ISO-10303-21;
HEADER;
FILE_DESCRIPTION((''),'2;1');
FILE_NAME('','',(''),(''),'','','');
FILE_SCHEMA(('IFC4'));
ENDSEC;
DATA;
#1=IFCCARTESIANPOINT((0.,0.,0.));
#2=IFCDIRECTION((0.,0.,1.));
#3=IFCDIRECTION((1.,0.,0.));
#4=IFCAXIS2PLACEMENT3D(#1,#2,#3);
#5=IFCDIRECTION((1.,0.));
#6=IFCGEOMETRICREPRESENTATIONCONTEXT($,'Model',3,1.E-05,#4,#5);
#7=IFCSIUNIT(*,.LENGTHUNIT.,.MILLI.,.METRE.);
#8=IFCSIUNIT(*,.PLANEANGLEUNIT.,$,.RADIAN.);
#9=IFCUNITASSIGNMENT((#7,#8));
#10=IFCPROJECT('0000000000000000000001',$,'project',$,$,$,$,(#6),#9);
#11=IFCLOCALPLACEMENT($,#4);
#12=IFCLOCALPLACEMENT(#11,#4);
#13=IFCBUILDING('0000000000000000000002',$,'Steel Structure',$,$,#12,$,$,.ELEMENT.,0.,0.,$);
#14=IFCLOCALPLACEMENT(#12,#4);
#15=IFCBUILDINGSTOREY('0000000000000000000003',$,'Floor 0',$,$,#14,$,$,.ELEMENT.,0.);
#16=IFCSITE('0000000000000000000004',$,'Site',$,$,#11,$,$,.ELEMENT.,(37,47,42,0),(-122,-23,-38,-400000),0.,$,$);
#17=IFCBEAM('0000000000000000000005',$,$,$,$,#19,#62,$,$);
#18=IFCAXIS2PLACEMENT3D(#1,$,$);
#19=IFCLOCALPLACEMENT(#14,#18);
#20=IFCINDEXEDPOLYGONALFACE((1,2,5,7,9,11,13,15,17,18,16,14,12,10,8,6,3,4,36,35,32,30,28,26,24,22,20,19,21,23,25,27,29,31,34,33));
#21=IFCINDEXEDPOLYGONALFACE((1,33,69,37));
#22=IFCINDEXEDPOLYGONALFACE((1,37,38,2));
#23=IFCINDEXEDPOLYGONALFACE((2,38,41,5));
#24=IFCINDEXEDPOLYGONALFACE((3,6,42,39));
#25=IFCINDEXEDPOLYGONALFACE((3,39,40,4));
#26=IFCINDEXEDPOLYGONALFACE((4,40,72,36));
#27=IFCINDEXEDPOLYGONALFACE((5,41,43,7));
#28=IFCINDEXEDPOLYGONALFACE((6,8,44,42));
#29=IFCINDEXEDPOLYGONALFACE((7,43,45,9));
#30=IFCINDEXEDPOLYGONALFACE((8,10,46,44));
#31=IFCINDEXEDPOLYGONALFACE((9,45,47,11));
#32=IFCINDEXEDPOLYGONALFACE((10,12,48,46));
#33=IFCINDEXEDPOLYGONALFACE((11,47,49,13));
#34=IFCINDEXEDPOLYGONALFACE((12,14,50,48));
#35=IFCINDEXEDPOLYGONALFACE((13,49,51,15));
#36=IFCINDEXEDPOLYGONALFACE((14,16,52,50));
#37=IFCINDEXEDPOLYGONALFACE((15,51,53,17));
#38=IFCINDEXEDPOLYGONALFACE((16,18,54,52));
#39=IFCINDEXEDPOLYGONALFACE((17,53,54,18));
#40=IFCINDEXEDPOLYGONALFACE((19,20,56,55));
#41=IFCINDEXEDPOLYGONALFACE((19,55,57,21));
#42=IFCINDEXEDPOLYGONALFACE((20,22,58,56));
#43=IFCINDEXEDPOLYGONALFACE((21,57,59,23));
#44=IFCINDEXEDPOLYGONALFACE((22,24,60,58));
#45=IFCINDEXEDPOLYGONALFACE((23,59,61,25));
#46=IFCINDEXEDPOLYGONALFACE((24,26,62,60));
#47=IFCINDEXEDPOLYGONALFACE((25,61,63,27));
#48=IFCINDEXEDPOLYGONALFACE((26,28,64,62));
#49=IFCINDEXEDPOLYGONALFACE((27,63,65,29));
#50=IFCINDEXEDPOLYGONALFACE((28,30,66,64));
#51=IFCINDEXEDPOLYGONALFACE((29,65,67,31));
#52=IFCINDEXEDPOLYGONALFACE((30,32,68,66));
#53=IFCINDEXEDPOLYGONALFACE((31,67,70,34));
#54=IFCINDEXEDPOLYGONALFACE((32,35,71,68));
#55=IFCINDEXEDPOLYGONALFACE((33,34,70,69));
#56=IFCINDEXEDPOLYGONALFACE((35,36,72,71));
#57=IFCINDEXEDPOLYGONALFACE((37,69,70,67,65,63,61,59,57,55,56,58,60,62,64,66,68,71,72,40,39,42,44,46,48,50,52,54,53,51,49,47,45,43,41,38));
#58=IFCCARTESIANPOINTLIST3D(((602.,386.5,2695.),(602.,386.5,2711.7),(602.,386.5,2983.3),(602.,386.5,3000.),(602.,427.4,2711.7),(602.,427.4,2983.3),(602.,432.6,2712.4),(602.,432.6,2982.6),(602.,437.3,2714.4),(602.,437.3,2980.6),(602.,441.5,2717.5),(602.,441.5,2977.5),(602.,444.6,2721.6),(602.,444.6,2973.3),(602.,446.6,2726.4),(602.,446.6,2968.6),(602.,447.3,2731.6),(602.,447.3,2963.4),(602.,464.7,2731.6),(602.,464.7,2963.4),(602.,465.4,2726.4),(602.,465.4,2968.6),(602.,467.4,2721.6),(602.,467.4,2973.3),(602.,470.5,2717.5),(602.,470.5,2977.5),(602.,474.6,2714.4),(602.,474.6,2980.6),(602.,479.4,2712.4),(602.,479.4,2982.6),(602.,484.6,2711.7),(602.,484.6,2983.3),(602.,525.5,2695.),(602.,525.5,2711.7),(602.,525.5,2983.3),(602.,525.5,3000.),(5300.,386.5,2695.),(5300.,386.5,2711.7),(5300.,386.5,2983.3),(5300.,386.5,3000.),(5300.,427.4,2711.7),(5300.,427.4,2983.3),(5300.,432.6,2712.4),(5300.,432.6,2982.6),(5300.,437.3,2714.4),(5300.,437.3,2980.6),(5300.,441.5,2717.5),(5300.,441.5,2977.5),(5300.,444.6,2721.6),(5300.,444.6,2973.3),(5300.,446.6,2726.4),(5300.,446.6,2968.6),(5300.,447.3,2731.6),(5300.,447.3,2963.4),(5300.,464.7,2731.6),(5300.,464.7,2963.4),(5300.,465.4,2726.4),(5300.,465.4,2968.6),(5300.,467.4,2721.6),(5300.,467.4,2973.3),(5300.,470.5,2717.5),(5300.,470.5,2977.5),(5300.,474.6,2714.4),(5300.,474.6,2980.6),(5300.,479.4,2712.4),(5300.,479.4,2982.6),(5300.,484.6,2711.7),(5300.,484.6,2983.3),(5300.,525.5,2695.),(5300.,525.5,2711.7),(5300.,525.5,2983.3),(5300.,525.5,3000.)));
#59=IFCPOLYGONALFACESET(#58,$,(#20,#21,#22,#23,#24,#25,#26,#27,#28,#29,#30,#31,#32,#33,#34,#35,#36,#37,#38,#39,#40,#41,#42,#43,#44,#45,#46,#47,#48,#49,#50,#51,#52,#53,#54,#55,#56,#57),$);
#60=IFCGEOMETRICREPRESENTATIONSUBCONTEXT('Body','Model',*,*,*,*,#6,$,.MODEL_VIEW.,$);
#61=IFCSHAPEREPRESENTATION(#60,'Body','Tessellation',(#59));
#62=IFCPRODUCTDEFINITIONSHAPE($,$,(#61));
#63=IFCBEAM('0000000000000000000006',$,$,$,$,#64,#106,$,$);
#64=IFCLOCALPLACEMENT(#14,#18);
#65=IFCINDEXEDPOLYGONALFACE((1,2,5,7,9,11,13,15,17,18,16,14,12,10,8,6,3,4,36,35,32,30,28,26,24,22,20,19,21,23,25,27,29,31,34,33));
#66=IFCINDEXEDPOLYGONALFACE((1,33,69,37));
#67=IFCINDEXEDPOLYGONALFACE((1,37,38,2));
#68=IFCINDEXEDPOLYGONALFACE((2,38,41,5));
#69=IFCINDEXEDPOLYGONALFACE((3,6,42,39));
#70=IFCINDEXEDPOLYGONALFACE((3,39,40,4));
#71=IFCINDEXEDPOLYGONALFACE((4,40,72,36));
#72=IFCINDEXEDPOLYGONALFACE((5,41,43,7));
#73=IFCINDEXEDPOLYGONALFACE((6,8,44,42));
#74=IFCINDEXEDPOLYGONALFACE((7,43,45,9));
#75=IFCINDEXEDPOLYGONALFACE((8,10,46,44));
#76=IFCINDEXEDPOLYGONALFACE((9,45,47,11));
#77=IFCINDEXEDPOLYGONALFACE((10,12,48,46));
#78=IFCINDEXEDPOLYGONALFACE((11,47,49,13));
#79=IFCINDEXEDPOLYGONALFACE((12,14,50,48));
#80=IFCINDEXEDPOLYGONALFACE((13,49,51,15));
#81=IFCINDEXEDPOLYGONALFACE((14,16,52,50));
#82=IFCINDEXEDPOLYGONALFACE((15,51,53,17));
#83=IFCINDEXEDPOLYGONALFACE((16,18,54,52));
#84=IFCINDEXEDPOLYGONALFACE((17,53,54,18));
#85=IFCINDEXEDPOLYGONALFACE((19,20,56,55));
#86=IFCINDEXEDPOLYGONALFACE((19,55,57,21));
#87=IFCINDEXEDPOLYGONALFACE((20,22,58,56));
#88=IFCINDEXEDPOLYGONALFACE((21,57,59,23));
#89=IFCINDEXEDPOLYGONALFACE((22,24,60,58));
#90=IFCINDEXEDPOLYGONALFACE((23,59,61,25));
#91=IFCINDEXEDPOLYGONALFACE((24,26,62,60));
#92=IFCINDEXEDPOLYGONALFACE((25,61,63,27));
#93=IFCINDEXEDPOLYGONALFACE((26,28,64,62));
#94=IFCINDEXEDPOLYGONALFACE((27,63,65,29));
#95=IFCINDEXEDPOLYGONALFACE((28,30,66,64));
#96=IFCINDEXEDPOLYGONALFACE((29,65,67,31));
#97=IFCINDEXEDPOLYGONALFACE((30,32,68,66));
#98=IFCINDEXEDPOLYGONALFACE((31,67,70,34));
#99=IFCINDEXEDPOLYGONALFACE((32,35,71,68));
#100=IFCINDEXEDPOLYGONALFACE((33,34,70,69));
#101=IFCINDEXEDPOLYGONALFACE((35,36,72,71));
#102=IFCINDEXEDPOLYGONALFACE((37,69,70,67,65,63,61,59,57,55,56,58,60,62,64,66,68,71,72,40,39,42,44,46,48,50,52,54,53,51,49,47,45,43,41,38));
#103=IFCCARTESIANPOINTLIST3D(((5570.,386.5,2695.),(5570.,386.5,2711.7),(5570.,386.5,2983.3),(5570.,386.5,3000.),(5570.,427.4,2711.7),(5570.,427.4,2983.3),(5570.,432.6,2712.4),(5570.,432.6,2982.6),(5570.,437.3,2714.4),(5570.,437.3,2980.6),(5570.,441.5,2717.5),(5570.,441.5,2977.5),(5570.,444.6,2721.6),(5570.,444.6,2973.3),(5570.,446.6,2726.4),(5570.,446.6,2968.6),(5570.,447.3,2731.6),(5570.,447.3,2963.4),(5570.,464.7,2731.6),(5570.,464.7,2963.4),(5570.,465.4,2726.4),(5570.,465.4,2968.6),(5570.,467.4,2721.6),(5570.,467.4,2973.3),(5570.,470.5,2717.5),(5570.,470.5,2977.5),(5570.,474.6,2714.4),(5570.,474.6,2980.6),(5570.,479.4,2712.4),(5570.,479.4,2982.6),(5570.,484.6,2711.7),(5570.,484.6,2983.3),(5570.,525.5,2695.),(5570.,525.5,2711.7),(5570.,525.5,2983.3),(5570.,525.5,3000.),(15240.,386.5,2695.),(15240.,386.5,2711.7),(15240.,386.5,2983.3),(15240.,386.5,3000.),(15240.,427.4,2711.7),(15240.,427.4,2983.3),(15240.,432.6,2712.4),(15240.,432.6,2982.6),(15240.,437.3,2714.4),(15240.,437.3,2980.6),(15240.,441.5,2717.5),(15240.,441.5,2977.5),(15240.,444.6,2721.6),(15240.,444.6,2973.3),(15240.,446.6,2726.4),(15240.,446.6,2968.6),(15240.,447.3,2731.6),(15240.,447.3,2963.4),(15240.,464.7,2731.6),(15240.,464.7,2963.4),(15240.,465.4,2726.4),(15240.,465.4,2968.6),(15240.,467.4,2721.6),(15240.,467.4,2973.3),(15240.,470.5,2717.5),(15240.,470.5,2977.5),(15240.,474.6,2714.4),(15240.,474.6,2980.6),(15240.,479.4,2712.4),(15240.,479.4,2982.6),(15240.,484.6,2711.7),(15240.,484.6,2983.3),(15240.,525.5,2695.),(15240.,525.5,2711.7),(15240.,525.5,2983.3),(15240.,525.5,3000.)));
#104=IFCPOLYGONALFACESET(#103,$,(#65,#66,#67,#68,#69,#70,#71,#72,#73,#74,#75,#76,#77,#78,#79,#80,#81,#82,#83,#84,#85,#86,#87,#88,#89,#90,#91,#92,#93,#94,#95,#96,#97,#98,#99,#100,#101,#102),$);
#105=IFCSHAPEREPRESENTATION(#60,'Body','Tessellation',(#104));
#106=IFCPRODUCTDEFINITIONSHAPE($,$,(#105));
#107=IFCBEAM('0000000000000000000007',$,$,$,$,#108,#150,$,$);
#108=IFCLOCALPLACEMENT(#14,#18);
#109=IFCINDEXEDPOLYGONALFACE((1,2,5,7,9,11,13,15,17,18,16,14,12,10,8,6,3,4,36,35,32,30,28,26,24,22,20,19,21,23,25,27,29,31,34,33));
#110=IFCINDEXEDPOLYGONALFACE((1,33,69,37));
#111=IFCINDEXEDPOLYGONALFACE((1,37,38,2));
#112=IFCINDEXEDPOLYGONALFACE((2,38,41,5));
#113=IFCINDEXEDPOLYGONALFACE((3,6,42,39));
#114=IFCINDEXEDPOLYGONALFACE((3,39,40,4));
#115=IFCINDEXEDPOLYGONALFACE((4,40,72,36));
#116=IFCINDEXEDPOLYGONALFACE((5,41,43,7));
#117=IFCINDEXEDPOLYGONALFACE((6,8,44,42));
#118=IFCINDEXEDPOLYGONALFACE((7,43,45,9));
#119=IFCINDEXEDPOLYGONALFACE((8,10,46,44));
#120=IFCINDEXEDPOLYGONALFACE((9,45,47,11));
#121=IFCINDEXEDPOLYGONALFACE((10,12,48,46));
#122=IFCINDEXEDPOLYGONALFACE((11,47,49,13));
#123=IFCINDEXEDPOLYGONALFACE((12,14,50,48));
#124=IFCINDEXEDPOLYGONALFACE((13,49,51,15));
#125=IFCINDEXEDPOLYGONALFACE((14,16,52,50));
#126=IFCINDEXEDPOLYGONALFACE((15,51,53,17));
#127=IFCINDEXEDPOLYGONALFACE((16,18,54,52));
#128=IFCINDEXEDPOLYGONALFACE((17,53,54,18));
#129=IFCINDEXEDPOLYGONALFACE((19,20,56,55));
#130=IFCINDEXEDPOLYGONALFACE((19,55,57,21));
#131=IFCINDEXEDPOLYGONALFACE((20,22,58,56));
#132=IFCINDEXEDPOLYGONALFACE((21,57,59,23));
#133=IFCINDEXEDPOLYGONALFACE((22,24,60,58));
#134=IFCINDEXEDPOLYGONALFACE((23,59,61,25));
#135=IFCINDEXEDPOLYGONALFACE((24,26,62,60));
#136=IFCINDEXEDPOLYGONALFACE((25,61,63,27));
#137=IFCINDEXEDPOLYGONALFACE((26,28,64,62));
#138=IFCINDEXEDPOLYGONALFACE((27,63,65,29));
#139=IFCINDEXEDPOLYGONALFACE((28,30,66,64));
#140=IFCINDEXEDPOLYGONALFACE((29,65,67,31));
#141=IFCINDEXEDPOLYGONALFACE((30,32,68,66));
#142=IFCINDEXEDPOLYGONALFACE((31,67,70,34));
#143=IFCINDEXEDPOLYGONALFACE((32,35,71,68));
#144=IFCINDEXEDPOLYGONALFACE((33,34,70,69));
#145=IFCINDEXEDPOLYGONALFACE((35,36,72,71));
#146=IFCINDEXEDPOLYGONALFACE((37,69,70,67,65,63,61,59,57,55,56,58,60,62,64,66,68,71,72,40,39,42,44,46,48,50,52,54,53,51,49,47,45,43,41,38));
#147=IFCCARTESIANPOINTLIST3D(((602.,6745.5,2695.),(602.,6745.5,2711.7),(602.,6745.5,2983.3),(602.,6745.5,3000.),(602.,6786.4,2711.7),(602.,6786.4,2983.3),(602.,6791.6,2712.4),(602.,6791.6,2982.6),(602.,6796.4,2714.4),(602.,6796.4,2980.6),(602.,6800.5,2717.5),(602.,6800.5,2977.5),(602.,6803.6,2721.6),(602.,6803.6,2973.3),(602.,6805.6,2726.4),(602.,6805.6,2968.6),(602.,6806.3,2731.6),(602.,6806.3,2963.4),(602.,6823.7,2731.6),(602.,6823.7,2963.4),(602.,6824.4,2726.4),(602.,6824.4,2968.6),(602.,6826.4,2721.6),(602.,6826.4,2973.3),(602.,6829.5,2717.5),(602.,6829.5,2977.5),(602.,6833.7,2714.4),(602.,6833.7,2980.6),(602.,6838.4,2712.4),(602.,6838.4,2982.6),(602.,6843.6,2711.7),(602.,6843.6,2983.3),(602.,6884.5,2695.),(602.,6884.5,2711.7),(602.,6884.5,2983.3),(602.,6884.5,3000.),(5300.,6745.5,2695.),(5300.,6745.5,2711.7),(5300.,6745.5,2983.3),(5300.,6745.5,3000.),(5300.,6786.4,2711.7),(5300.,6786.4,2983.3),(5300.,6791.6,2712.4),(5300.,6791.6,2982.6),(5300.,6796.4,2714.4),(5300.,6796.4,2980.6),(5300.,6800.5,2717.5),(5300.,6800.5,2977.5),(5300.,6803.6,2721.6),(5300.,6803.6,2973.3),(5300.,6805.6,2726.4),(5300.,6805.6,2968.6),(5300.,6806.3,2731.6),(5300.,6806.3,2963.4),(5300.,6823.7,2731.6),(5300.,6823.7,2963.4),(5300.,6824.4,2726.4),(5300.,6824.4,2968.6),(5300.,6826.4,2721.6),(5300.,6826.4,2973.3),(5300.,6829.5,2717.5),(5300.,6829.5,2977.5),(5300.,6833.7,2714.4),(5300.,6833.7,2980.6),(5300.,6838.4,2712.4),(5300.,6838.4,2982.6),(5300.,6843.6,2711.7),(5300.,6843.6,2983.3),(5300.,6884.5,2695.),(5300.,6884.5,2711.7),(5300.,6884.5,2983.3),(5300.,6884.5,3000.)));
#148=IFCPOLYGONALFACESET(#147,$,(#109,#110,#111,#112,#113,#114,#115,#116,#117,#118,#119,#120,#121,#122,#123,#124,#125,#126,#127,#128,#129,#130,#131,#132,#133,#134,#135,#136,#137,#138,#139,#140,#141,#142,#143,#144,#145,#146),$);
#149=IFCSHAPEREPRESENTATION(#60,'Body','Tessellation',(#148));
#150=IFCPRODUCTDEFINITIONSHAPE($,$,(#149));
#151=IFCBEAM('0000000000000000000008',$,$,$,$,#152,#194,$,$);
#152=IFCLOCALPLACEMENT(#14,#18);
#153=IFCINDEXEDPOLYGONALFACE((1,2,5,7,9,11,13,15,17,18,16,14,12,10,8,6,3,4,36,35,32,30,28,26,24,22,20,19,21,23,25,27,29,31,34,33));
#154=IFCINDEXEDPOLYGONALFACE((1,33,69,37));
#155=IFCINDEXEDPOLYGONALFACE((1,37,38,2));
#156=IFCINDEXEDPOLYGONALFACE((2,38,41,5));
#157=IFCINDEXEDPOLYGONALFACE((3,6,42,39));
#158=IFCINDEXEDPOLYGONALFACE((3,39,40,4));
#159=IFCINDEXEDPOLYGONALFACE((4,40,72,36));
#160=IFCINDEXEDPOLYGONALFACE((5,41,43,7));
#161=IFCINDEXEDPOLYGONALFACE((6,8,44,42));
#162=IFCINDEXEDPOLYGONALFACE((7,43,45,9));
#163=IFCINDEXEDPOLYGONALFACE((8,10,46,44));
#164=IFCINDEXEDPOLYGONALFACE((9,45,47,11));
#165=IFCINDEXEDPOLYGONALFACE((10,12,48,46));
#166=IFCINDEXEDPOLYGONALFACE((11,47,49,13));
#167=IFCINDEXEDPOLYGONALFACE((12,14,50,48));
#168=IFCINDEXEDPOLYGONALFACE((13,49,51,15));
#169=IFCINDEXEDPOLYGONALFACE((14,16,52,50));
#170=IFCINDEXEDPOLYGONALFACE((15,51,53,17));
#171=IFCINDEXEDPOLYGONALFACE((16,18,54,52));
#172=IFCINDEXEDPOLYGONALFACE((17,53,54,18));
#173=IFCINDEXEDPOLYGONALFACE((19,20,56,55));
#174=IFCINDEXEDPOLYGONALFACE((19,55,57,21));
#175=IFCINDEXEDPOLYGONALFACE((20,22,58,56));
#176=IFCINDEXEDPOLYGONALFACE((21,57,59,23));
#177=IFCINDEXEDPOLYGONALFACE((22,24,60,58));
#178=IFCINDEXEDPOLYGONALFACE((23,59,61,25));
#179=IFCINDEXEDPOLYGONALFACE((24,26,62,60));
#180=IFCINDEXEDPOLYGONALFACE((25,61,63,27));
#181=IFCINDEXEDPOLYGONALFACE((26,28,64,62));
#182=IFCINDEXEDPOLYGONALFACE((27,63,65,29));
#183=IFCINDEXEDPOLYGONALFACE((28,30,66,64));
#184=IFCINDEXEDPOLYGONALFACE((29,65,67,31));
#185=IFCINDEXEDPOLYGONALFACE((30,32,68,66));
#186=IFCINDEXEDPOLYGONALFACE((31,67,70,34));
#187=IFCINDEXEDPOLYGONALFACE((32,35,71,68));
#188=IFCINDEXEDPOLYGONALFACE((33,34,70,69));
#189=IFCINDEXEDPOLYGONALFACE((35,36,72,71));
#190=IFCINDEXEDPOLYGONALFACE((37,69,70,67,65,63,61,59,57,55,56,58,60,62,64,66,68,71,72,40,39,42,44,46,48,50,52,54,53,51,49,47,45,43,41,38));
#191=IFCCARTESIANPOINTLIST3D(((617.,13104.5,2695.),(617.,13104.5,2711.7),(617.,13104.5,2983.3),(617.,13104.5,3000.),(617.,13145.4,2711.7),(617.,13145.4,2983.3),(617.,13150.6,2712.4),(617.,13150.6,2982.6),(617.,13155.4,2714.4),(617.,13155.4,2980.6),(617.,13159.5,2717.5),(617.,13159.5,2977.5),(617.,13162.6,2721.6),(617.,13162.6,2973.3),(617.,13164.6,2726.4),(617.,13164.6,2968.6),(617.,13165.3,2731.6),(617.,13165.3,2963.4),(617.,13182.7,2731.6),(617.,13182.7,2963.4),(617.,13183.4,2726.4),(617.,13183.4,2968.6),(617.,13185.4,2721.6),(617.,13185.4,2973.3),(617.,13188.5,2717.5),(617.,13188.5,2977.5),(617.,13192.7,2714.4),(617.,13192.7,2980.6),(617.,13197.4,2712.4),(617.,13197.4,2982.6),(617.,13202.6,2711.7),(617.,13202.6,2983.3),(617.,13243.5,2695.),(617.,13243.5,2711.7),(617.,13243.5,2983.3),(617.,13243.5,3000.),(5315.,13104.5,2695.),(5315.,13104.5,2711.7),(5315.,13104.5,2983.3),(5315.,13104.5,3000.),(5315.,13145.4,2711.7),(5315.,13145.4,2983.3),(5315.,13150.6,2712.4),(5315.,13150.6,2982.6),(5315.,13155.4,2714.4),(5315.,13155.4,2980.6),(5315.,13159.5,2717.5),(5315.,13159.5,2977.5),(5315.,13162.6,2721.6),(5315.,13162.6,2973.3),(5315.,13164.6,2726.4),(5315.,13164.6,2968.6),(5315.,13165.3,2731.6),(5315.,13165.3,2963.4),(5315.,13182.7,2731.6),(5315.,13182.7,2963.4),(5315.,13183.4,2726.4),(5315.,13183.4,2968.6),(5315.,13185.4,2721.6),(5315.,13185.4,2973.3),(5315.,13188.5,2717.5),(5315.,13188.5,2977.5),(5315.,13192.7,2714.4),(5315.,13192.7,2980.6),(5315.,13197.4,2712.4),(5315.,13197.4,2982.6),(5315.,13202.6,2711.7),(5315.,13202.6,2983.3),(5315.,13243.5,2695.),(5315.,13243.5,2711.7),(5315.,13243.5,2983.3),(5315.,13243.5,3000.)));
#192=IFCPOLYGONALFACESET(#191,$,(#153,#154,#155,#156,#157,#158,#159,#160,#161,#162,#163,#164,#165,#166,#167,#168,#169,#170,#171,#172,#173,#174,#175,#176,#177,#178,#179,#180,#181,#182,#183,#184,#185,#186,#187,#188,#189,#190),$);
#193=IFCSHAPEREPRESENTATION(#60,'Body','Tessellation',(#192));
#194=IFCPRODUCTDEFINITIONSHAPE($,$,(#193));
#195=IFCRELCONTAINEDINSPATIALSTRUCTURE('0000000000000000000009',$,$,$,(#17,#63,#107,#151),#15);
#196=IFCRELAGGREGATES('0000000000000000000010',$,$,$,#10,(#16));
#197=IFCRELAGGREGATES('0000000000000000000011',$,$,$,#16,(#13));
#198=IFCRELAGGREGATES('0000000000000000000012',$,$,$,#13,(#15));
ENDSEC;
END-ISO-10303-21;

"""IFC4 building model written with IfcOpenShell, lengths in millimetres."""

from ifc_helpers import new_model, si_unit, direction, frame, origin_with_axes, origin_2d_with_axis, place, context, subcontext, project, spatial, i_section, extrude, element, save


model = new_model("IFC4")

# Units and contexts
model_context = context("Model", 3, precision=1e-05, world=origin_with_axes(), true_north=direction((1.0, 0.0)))
body_context = subcontext(model_context, "Body", "Model", "MODEL_VIEW")
ifc_project = project(units=[si_unit("LENGTHUNIT", "METRE", prefix="MILLI"), si_unit("PLANEANGLEUNIT", "RADIAN")], contexts=[model_context])

# Site, building, storey
site_placement = place(None, origin_with_axes())
site = spatial("IfcSite", under=ifc_project, at=site_placement, Name="Site", CompositionType="ELEMENT", RefLatitude=(37, 47, 42, 0), RefLongitude=(-122, -23, -38, -400000), RefElevation=0.0)
building_placement = place(site_placement, origin_with_axes())
building = spatial("IfcBuilding", under=site, at=building_placement, Name="Steel Structure", CompositionType="ELEMENT", ElevationOfRefHeight=0.0, ElevationOfTerrain=0.0)
storey_placement = place(building_placement, origin_with_axes())
storey = spatial("IfcBuildingStorey", under=building, at=storey_placement, Name="Floor 0", CompositionType="ELEMENT", Elevation=0.0)

# Beams
beam_1_placement = place(storey_placement, frame((602.0, 456.0, 2695.0), z_axis=(1.0, 0.0, 0.0), x_axis=(0.0, 1.0, 0.0)))
element("IfcBeam", 1, at=beam_1_placement, inside=storey, context=body_context, shape_type="SweptSolid", body=[
    extrude(i_section(OverallWidth=139.0, OverallDepth=305.0, WebThickness=17.4, FlangeThickness=16.7, FilletRadius=19.9, at=origin_2d_with_axis()), frame((0.0, 152.5, 0.0), z_axis=(0.0, 0.0, 1.0), x_axis=(1.0, 0.0, 0.0)), (0.0, 0.0, 1.0), 4698.0),
])
beam_2_placement = place(storey_placement, frame((5570.0, 456.0, 2695.0), z_axis=(1.0, 0.0, 0.0), x_axis=(0.0, 1.0, 0.0)))
element("IfcBeam", 2, at=beam_2_placement, inside=storey, context=body_context, shape_type="SweptSolid", body=[
    extrude(i_section(OverallWidth=139.0, OverallDepth=305.0, WebThickness=17.4, FlangeThickness=16.7, FilletRadius=19.9, at=origin_2d_with_axis()), frame((0.0, 152.5, 0.0), z_axis=(0.0, 0.0, 1.0), x_axis=(1.0, 0.0, 0.0)), (0.0, 0.0, 1.0), 9670.0),
])
beam_3_placement = place(storey_placement, frame((602.0, 6815.0, 2695.0), z_axis=(1.0, 0.0, 0.0), x_axis=(0.0, 1.0, 0.0)))
element("IfcBeam", 3, at=beam_3_placement, inside=storey, context=body_context, shape_type="SweptSolid", body=[
    extrude(i_section(OverallWidth=139.0, OverallDepth=305.0, WebThickness=17.4, FlangeThickness=16.7, FilletRadius=19.9, at=origin_2d_with_axis()), frame((0.0, 152.5, 0.0), z_axis=(0.0, 0.0, 1.0), x_axis=(1.0, 0.0, 0.0)), (0.0, 0.0, 1.0), 4698.0),
])
beam_4_placement = place(storey_placement, frame((5315.0, 13174.0, 2695.0), z_axis=(-1.0, 0.0, 0.0), x_axis=(0.0, -1.0, 0.0)))
element("IfcBeam", 4, at=beam_4_placement, inside=storey, context=body_context, shape_type="SweptSolid", body=[
    extrude(i_section(OverallWidth=139.0, OverallDepth=305.0, WebThickness=17.4, FlangeThickness=16.7, FilletRadius=19.9, at=origin_2d_with_axis()), frame((0.0, 152.5, 0.0), z_axis=(0.0, 0.0, 1.0), x_axis=(1.0, 0.0, 0.0)), (0.0, 0.0, 1.0), 4698.0),
])

save(model, "model.ifc")
